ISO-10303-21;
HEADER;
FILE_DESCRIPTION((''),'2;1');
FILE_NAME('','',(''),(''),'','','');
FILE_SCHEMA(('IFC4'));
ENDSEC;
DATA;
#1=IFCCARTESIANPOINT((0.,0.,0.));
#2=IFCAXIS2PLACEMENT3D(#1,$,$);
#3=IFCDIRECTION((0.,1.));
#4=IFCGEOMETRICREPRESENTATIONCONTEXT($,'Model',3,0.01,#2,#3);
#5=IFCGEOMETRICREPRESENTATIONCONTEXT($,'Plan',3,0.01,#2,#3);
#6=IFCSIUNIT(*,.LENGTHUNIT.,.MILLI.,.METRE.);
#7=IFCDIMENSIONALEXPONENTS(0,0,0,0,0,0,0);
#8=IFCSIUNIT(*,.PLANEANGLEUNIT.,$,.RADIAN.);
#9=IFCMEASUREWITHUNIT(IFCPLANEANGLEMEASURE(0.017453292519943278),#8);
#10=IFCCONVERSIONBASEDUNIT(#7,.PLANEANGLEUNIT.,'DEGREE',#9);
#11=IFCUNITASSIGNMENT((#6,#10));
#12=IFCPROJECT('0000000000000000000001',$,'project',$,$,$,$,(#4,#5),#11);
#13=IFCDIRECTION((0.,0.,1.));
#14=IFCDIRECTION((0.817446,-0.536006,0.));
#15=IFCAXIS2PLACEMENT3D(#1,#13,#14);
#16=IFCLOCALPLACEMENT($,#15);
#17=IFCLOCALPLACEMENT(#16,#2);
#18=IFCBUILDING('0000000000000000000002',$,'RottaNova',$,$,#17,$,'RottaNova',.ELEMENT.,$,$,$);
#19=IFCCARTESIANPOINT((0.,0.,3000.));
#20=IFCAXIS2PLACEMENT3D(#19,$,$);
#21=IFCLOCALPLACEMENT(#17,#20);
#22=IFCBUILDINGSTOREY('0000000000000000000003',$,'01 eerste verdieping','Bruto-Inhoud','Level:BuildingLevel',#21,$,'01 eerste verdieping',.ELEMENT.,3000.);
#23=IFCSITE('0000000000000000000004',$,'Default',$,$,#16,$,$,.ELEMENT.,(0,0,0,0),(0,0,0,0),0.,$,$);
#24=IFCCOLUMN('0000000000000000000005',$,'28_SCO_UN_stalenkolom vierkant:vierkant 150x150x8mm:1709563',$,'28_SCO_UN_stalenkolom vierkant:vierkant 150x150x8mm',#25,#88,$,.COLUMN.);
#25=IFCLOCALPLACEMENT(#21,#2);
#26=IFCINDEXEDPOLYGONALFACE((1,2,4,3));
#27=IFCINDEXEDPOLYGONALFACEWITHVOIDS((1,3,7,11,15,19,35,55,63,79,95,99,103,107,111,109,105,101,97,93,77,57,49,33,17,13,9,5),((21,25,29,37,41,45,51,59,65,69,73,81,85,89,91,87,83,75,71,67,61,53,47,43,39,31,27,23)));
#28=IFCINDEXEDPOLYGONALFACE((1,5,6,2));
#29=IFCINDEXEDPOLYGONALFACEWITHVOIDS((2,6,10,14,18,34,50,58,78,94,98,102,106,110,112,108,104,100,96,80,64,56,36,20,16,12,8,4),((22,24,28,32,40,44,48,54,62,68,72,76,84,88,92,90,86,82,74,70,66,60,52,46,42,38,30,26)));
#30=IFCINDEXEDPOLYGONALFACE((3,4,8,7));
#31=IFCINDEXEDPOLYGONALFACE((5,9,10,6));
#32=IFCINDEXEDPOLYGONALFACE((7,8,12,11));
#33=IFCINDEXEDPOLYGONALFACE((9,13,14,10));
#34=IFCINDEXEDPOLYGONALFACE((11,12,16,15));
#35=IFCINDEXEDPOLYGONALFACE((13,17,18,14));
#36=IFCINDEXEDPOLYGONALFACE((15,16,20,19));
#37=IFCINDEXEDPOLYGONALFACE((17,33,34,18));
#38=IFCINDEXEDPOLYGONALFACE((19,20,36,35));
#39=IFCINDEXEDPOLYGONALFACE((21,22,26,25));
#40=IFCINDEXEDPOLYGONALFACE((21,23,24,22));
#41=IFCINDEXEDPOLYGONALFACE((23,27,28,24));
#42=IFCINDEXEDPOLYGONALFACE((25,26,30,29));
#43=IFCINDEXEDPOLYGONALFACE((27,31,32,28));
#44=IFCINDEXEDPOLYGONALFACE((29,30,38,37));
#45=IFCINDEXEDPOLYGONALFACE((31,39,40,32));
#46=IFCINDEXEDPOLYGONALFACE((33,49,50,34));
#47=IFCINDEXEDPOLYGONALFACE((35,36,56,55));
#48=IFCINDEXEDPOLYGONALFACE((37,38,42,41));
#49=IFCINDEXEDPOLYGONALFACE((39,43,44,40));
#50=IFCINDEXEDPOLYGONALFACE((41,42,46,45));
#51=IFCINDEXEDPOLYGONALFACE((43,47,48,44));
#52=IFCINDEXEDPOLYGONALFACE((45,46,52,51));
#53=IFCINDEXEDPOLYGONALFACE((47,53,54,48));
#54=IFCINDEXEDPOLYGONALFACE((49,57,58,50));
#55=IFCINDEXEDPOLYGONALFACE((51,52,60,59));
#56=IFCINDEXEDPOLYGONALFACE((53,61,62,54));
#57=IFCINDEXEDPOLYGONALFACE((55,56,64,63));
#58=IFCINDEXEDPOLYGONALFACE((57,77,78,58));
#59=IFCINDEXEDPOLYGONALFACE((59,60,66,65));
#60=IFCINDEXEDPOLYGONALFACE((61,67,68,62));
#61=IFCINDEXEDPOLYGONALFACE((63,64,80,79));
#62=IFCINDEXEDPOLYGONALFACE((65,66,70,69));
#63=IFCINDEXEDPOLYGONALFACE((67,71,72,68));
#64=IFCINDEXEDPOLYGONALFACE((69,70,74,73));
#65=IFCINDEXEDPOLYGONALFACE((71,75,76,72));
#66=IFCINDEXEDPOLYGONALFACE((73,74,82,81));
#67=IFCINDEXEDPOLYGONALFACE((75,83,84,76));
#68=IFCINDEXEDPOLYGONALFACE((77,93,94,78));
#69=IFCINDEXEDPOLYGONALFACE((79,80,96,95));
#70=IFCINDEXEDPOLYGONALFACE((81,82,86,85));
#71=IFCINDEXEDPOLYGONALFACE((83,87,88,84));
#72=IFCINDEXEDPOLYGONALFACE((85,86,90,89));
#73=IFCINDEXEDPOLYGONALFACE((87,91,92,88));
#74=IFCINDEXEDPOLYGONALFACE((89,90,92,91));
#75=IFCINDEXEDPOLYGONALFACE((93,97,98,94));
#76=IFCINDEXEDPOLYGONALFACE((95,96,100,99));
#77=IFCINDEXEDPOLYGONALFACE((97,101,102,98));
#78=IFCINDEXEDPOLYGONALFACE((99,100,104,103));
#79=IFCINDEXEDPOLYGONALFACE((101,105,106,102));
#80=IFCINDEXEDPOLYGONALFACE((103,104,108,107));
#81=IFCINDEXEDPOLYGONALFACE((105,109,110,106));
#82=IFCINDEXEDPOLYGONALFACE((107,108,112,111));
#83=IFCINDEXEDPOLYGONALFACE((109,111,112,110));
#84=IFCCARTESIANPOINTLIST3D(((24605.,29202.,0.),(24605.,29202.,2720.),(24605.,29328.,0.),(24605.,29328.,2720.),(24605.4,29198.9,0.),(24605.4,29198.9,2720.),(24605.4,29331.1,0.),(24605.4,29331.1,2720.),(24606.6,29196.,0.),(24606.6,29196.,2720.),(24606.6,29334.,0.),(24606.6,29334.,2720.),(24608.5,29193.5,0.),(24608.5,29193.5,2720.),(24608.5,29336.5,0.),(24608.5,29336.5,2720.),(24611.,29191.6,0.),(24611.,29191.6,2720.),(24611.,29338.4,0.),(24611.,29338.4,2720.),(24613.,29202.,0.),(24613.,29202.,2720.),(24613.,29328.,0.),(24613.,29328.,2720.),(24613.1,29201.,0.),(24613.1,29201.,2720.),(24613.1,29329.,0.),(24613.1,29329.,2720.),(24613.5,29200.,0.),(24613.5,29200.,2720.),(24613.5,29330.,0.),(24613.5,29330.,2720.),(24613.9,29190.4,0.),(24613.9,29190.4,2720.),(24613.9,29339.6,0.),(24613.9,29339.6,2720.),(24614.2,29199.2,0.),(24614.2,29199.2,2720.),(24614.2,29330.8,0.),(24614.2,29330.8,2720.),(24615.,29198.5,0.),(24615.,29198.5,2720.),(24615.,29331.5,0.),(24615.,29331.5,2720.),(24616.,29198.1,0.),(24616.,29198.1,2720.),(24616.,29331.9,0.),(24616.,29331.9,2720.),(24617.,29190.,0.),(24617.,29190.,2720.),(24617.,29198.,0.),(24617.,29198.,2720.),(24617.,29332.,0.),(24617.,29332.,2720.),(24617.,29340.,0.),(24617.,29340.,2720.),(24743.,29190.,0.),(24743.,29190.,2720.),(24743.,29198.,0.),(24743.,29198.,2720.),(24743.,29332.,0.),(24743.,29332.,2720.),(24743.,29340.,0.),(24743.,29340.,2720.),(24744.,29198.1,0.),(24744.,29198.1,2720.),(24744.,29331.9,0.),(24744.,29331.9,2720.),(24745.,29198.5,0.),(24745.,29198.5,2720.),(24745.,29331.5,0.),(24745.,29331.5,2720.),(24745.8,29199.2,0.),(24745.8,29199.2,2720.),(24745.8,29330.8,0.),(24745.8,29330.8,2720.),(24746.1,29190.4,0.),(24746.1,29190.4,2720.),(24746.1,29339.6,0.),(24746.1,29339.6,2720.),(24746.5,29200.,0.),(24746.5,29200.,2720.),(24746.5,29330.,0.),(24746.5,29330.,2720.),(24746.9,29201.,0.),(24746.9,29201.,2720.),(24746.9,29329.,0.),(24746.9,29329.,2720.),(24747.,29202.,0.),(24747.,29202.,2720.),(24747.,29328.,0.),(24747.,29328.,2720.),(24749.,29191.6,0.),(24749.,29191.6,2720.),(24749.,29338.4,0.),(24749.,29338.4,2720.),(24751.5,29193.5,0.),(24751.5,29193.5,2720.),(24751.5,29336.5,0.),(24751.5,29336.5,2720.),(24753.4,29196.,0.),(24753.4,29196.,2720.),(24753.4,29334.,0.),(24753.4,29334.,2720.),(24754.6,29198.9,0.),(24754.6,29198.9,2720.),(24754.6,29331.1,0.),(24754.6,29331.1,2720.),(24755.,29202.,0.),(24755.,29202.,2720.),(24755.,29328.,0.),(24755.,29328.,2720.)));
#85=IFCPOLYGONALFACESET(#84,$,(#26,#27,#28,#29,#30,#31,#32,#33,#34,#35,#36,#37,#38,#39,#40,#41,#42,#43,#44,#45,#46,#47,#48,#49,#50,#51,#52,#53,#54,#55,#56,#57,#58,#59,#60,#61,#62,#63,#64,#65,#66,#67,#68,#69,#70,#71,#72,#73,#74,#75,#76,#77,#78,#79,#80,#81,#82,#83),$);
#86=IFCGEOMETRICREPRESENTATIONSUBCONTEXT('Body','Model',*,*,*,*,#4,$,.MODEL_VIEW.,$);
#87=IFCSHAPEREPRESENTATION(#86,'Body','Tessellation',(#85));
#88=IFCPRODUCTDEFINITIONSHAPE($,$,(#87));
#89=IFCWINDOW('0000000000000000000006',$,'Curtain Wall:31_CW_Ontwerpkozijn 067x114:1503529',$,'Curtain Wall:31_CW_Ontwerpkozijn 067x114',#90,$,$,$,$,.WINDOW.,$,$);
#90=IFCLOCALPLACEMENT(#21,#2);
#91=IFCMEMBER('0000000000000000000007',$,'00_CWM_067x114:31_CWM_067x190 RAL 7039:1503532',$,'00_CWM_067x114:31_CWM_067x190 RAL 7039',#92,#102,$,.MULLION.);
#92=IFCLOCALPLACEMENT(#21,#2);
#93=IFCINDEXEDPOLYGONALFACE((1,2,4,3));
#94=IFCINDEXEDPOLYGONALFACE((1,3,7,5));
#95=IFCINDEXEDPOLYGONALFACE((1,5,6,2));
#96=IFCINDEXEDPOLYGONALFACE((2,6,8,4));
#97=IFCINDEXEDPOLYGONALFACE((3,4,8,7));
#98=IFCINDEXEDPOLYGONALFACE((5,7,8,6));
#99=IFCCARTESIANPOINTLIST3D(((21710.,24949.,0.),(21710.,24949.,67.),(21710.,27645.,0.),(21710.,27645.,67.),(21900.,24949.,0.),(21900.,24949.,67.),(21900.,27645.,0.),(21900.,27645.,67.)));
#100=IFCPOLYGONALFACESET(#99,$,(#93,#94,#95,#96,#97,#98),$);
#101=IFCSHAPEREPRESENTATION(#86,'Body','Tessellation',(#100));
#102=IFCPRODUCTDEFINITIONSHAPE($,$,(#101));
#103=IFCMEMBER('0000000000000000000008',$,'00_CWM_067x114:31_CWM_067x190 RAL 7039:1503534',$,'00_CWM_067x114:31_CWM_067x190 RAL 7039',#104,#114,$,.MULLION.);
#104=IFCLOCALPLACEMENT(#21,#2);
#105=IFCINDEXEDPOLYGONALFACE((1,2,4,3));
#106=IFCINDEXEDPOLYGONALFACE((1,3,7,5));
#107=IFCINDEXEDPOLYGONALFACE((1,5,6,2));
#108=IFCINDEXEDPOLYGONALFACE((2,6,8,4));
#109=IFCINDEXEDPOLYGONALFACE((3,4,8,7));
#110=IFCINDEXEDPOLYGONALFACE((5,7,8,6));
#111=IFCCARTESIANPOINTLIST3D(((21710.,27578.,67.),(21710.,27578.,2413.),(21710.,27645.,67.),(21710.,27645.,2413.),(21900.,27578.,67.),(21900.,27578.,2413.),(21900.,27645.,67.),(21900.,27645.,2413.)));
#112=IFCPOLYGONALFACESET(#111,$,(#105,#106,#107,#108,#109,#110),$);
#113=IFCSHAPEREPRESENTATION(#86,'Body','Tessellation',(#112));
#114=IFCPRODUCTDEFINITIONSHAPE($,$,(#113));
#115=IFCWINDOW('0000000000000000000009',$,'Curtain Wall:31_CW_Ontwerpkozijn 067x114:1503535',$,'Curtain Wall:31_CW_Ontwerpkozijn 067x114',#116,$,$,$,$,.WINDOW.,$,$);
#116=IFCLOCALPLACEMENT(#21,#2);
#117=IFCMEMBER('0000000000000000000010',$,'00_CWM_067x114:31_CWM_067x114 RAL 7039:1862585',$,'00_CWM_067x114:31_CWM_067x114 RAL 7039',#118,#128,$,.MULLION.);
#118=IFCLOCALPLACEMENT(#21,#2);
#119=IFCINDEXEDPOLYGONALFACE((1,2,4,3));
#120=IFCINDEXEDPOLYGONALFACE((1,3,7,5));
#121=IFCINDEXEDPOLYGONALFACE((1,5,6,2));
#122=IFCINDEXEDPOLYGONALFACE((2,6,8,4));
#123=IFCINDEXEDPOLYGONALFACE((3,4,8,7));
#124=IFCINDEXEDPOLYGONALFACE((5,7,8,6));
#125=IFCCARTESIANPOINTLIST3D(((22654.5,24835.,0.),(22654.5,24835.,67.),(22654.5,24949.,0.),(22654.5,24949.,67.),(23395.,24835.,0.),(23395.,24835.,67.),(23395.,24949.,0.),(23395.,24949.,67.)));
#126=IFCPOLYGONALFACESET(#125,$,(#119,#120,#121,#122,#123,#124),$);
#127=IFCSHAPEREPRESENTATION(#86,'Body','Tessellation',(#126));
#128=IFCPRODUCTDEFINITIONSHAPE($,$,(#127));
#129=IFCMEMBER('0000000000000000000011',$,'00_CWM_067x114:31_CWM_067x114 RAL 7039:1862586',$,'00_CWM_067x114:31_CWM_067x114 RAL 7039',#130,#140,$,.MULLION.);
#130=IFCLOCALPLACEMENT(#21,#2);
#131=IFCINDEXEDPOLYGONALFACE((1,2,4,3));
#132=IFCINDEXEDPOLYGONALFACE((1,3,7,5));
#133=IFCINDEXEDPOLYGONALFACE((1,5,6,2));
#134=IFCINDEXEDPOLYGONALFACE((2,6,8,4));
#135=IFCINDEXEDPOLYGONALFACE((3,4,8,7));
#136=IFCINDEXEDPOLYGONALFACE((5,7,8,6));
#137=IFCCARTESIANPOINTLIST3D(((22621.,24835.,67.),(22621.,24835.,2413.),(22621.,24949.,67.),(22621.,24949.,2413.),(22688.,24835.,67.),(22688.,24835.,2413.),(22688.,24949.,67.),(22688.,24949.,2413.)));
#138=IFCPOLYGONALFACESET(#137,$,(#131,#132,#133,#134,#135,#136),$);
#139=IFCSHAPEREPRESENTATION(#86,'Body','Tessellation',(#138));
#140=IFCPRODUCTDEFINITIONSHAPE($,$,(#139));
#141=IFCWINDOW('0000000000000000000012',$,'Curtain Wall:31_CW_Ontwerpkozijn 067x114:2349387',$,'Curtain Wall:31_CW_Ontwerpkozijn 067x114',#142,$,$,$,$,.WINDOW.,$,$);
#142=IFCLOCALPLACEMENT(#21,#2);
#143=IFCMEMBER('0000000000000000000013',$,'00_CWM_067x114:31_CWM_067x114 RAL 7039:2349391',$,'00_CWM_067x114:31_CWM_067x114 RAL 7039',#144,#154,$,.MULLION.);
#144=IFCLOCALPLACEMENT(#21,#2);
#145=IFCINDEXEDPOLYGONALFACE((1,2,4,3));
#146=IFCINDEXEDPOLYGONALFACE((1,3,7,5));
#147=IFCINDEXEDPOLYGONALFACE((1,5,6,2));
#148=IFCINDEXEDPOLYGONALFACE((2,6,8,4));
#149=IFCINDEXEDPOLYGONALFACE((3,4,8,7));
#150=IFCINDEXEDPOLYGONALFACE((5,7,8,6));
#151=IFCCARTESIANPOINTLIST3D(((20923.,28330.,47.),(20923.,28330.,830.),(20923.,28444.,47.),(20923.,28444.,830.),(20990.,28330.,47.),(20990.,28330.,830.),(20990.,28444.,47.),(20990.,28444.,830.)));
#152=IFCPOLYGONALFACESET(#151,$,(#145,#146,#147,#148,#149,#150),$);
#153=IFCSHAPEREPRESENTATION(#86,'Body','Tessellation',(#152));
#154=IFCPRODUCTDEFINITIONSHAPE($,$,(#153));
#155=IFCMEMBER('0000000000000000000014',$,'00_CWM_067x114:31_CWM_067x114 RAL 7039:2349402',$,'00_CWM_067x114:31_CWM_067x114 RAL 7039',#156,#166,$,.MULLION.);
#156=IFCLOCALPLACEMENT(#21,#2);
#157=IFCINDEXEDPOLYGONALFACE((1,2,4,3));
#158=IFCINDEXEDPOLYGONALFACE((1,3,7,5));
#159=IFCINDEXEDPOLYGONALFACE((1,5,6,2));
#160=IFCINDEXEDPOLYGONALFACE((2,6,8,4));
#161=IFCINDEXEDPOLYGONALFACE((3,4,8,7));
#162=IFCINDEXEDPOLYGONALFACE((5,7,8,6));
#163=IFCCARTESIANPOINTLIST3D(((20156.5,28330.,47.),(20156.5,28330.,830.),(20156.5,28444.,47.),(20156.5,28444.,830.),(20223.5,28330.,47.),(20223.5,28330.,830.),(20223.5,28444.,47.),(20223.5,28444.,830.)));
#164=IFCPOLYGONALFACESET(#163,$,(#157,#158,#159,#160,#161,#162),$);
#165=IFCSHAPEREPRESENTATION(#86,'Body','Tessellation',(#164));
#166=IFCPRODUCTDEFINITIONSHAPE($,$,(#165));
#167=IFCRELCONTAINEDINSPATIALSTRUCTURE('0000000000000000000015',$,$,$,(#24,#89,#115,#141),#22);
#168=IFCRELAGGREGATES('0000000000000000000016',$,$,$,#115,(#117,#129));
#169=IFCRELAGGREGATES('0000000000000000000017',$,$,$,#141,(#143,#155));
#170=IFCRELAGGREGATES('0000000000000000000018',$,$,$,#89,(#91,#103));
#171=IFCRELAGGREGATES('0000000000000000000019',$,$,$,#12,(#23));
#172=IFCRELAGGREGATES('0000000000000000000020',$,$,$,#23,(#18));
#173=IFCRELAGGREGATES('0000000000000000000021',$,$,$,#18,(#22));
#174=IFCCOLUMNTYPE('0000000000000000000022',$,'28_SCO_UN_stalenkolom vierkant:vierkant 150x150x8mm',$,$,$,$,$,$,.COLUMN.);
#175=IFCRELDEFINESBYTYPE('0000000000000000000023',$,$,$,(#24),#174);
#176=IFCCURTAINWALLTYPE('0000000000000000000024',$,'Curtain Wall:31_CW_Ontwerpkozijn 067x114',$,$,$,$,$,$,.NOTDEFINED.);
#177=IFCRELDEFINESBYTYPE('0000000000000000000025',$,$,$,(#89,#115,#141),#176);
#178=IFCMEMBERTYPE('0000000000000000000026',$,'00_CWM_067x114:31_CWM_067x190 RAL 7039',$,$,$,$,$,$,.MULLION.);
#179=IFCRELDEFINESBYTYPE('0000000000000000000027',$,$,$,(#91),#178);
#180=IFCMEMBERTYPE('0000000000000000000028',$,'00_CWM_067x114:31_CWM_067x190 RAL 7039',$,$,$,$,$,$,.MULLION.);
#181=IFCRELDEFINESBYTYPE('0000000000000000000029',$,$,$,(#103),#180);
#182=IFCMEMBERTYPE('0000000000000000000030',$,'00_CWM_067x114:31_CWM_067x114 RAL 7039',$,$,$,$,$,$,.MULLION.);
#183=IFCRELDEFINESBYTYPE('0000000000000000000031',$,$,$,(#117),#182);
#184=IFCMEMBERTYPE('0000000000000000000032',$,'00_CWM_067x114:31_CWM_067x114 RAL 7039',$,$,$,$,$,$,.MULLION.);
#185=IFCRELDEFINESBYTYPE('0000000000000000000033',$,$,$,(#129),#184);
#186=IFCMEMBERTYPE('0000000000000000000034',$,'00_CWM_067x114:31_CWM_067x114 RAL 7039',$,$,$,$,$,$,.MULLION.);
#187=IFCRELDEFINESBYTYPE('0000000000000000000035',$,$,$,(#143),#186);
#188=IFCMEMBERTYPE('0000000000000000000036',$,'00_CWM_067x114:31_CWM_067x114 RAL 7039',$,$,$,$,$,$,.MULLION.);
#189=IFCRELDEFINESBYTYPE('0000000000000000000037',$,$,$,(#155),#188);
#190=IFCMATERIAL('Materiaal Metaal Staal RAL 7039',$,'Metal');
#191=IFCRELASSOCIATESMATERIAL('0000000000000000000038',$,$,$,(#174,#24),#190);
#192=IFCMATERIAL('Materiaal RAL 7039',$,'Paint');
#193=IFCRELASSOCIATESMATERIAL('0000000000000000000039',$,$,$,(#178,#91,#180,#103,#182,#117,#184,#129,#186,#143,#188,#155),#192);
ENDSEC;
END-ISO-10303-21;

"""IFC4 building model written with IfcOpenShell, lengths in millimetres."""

from ifc_helpers import new_model, entity, si_unit, converted_unit, direction, frame, origin, place, context, subcontext, project, spatial, line, arc, indexed_curve, outline, extrude, source, transform, mapped, material, type_object, type_shapes, element, aggregate, save


model = new_model("IFC4")

# Units and contexts
model_context = context("Model", 3, precision=0.01, world=origin(), true_north=direction((0.0, 1.0)))
plan_context = context("Plan", 3, precision=0.01, world=origin(), true_north=direction((0.0, 1.0)))
body_context = subcontext(model_context, "Body", "Model", "MODEL_VIEW")
ifc_project = project(units=[si_unit("LENGTHUNIT", "METRE", prefix="MILLI"), converted_unit("PLANEANGLEUNIT", "DEGREE", entity("IfcPlaneAngleMeasure", 0.017453292519943278), si_unit("PLANEANGLEUNIT", "RADIAN"), dimensions=[0, 0, 0, 0, 0, 0, 0])], contexts=[model_context, plan_context])

# Site, building, storey
site_placement = place(None, frame((0.0, 0.0, 0.0), z_axis=(0.0, 0.0, 1.0), x_axis=(0.817446, -0.536006, 0.0)))
site = spatial("IfcSite", under=ifc_project, at=site_placement, Name="Default", CompositionType="ELEMENT", RefLatitude=(0, 0, 0, 0), RefLongitude=(0, 0, 0, 0), RefElevation=0.0)
building_placement = place(site_placement, origin())
building = spatial("IfcBuilding", under=site, at=building_placement, Name="RottaNova", LongName="RottaNova", CompositionType="ELEMENT")
storey_placement = place(building_placement, frame((0.0, 0.0, 3000.0)))
storey = spatial("IfcBuildingStorey", under=building, at=storey_placement, Name="01 eerste verdieping", Description="Bruto-Inhoud", ObjectType="Level:BuildingLevel", LongName="01 eerste verdieping", CompositionType="ELEMENT", Elevation=3000.0)

# Column
ifc_material_1 = material(Name="Materiaal Metaal Staal RAL 7039", Category="Metal")
column_type = type_object("IfcColumnType", Name="28_SCO_UN_stalenkolom vierkant:vierkant 150x150x8mm", PredefinedType="COLUMN", material=ifc_material_1)
shared_shape_1 = source(origin(), body_context, "Body", "SweptSolid", [
    extrude(outline(indexed_curve([(-63.0, -75.0), (63.0, -75.0), (71.5, -71.5), (75.0, -63.0), (75.0, 63.0), (71.5, 71.5), (63.0, 75.0), (-63.0, 75.0), (-71.5, 71.5), (-75.0, 63.0), (-75.0, -63.0), (-71.5, -71.5)], segments=[line(1, 2), arc(2, 3, 4), line(4, 5), arc(5, 6, 7), line(7, 8), arc(8, 9, 10), line(10, 11), arc(11, 12, 1)], self_intersect=False), holes=[indexed_curve([(67.0, -63.0), (65.8, -65.8), (63.0, -67.0), (-63.0, -67.0), (-65.8, -65.8), (-67.0, -63.0), (-67.0, 63.0), (-65.8, 65.8), (-63.0, 67.0), (63.0, 67.0), (65.8, 65.8), (67.0, 63.0)], segments=[arc(1, 2, 3), line(3, 4), arc(4, 5, 6), line(6, 7), arc(7, 8, 9), line(9, 10), arc(10, 11, 12), line(12, 1)], self_intersect=False)]), frame((0.0, 0.0, 3000.0), z_axis=(0.0, 0.0, 1.0), x_axis=(-1.0, 0.0, 0.0)), (0.0, 0.0, 1.0), 2720.0),
])
type_shapes(column_type, [shared_shape_1])
column_placement = place(storey_placement, frame((24680.0, 29265.0, -3000.0)))
element("IfcColumn", 1, at=column_placement, inside=storey, type_object=column_type, material=ifc_material_1, Name="28_SCO_UN_stalenkolom vierkant:vierkant 150x150x8mm:1709563", ObjectType="28_SCO_UN_stalenkolom vierkant:vierkant 150x150x8mm", PredefinedType="COLUMN", context=body_context, shape_type="MappedRepresentation", body=[
    mapped(shared_shape_1, transform((0.0, 0.0, 0.0), scale=1.0)),
])

# Windows, members
curtain_wall_type = type_object("IfcCurtainWallType", Name="Curtain Wall:31_CW_Ontwerpkozijn 067x114", PredefinedType="NOTDEFINED")
window_1_placement = place(storey_placement, frame((0.0, 0.0, -3000.0)))
window_1 = element("IfcWindow", 2, at=window_1_placement, inside=storey, type_object=curtain_wall_type, Name="Curtain Wall:31_CW_Ontwerpkozijn 067x114:1503529", ObjectType="Curtain Wall:31_CW_Ontwerpkozijn 067x114", PredefinedType="WINDOW")
ifc_material_2 = material(Name="Materiaal RAL 7039", Category="Paint")
member_type_1 = type_object("IfcMemberType", Name="00_CWM_067x114:31_CWM_067x190 RAL 7039", PredefinedType="MULLION", material=ifc_material_2)
shared_shape_2 = source(origin(), body_context, "Body", "SweptSolid", [
    extrude(outline(indexed_curve([(-33.5, -95.0), (33.5, -95.0), (33.5, 95.0), (-33.5, 95.0), (-33.5, -95.0)], self_intersect=False)), frame((-33.5, -95.0, -2696.0), z_axis=(0.0, 0.0, 1.0), x_axis=(-1.0, 0.0, 0.0)), (0.0, 0.0, 1.0), 2696.0),
])
type_shapes(member_type_1, [shared_shape_2])
member_1_placement = place(window_1_placement, frame((21710.0, 27645.0, 3000.0), z_axis=(0.0, 1.0, 0.0), x_axis=(0.0, 0.0, -1.0)))
member_1 = element("IfcMember", 3, at=member_1_placement, type_object=member_type_1, material=ifc_material_2, Name="00_CWM_067x114:31_CWM_067x190 RAL 7039:1503532", ObjectType="00_CWM_067x114:31_CWM_067x190 RAL 7039", PredefinedType="MULLION", context=body_context, shape_type="MappedRepresentation", body=[
    mapped(shared_shape_2, transform((0.0, 0.0, 0.0), scale=1.0)),
])
member_type_2 = type_object("IfcMemberType", Name="00_CWM_067x114:31_CWM_067x190 RAL 7039", PredefinedType="MULLION", material=ifc_material_2)
shared_shape_3 = source(origin(), body_context, "Body", "SweptSolid", [
    extrude(outline(indexed_curve([(-33.5, -95.0), (33.5, -95.0), (33.5, 95.0), (-33.5, 95.0), (-33.5, -95.0)], self_intersect=False)), frame((-33.5, -95.0, -2346.0), z_axis=(0.0, 0.0, 1.0), x_axis=(-1.0, 0.0, 0.0)), (0.0, 0.0, 1.0), 2346.0),
])
type_shapes(member_type_2, [shared_shape_3])
member_2_placement = place(window_1_placement, frame((21710.0, 27645.0, 5413.0), z_axis=(0.0, 0.0, 1.0), x_axis=(0.0, 1.0, 0.0)))
member_2 = element("IfcMember", 4, at=member_2_placement, type_object=member_type_2, material=ifc_material_2, Name="00_CWM_067x114:31_CWM_067x190 RAL 7039:1503534", ObjectType="00_CWM_067x114:31_CWM_067x190 RAL 7039", PredefinedType="MULLION", context=body_context, shape_type="MappedRepresentation", body=[
    mapped(shared_shape_3, transform((0.0, 0.0, 0.0), scale=1.0)),
])
window_2_placement = place(storey_placement, frame((0.0, 0.0, -3000.0)))
window_2 = element("IfcWindow", 5, at=window_2_placement, inside=storey, type_object=curtain_wall_type, Name="Curtain Wall:31_CW_Ontwerpkozijn 067x114:1503535", ObjectType="Curtain Wall:31_CW_Ontwerpkozijn 067x114", PredefinedType="WINDOW")
member_type_3 = type_object("IfcMemberType", Name="00_CWM_067x114:31_CWM_067x114 RAL 7039", PredefinedType="MULLION", material=ifc_material_2)
shared_shape_4 = source(origin(), body_context, "Body", "SweptSolid", [
    extrude(outline(indexed_curve([(-33.5, -57.0), (33.5, -57.0), (33.5, 57.0), (-33.5, 57.0), (-33.5, -57.0)], self_intersect=False)), frame((-33.5, -57.0, -740.5), z_axis=(0.0, 0.0, 1.0), x_axis=(-1.0, 0.0, 0.0)), (0.0, 0.0, 1.0), 740.5),
])
type_shapes(member_type_3, [shared_shape_4])
member_3_placement = place(window_2_placement, frame((22654.5, 24835.0, 3000.0), z_axis=(-1.0, 0.0, 0.0), x_axis=(0.0, 0.0, -1.0)))
member_3 = element("IfcMember", 6, at=member_3_placement, type_object=member_type_3, material=ifc_material_2, Name="00_CWM_067x114:31_CWM_067x114 RAL 7039:1862585", ObjectType="00_CWM_067x114:31_CWM_067x114 RAL 7039", PredefinedType="MULLION", context=body_context, shape_type="MappedRepresentation", body=[
    mapped(shared_shape_4, transform((0.0, 0.0, 0.0), scale=1.0)),
])
member_type_4 = type_object("IfcMemberType", Name="00_CWM_067x114:31_CWM_067x114 RAL 7039", PredefinedType="MULLION", material=ifc_material_2)
shared_shape_5 = source(origin(), body_context, "Body", "SweptSolid", [
    extrude(outline(indexed_curve([(-33.5, -57.0), (33.5, -57.0), (33.5, 57.0), (-33.5, 57.0), (-33.5, -57.0)], self_intersect=False)), frame((0.0, -57.0, -2346.0), z_axis=(0.0, 0.0, 1.0), x_axis=(-1.0, 0.0, 0.0)), (0.0, 0.0, 1.0), 2346.0),
])
type_shapes(member_type_4, [shared_shape_5])
member_4_placement = place(window_2_placement, frame((22654.5, 24835.0, 3067.0), z_axis=(0.0, 0.0, -1.0), x_axis=(1.0, 0.0, 0.0)))
member_4 = element("IfcMember", 7, at=member_4_placement, type_object=member_type_4, material=ifc_material_2, Name="00_CWM_067x114:31_CWM_067x114 RAL 7039:1862586", ObjectType="00_CWM_067x114:31_CWM_067x114 RAL 7039", PredefinedType="MULLION", context=body_context, shape_type="MappedRepresentation", body=[
    mapped(shared_shape_5, transform((0.0, 0.0, 0.0), scale=1.0)),
])
aggregate(window_2, [member_3, member_4])

# Window, members
window_3_placement = place(storey_placement, frame((0.0, 0.0, -3000.0)))
window_3 = element("IfcWindow", 8, at=window_3_placement, inside=storey, type_object=curtain_wall_type, Name="Curtain Wall:31_CW_Ontwerpkozijn 067x114:2349387", ObjectType="Curtain Wall:31_CW_Ontwerpkozijn 067x114", PredefinedType="WINDOW")
member_type_5 = type_object("IfcMemberType", Name="00_CWM_067x114:31_CWM_067x114 RAL 7039", PredefinedType="MULLION", material=ifc_material_2)
shared_shape_6 = source(origin(), body_context, "Body", "SweptSolid", [
    extrude(outline(indexed_curve([(-33.5, -57.0), (33.5, -57.0), (33.5, 57.0), (-33.5, 57.0), (-33.5, -57.0)], self_intersect=False)), frame((-33.5, -57.0, -783.0), z_axis=(0.0, 0.0, 1.0), x_axis=(-1.0, 0.0, 0.0)), (0.0, 0.0, 1.0), 783.0),
])
type_shapes(member_type_5, [shared_shape_6])
member_5_placement = place(window_3_placement, frame((20990.0, 28330.0, 3047.0), z_axis=(0.0, 0.0, -1.0), x_axis=(1.0, 0.0, 0.0)))
member_5 = element("IfcMember", 9, at=member_5_placement, type_object=member_type_5, material=ifc_material_2, Name="00_CWM_067x114:31_CWM_067x114 RAL 7039:2349391", ObjectType="00_CWM_067x114:31_CWM_067x114 RAL 7039", PredefinedType="MULLION", context=body_context, shape_type="MappedRepresentation", body=[
    mapped(shared_shape_6, transform((0.0, 0.0, 0.0), scale=1.0)),
])
member_type_6 = type_object("IfcMemberType", Name="00_CWM_067x114:31_CWM_067x114 RAL 7039", PredefinedType="MULLION", material=ifc_material_2)
shared_shape_7 = source(origin(), body_context, "Body", "SweptSolid", [
    extrude(outline(indexed_curve([(-33.5, -57.0), (33.5, -57.0), (33.5, 57.0), (-33.5, 57.0), (-33.5, -57.0)], self_intersect=False)), frame((0.0, -57.0, -783.0), z_axis=(0.0, 0.0, 1.0), x_axis=(-1.0, 0.0, 0.0)), (0.0, 0.0, 1.0), 783.0),
])
type_shapes(member_type_6, [shared_shape_7])
member_6_placement = place(window_3_placement, frame((20190.0, 28330.0, 3047.0), z_axis=(0.0, 0.0, -1.0), x_axis=(1.0, 0.0, 0.0)))
member_6 = element("IfcMember", 10, at=member_6_placement, type_object=member_type_6, material=ifc_material_2, Name="00_CWM_067x114:31_CWM_067x114 RAL 7039:2349402", ObjectType="00_CWM_067x114:31_CWM_067x114 RAL 7039", PredefinedType="MULLION", context=body_context, shape_type="MappedRepresentation", body=[
    mapped(shared_shape_7, transform((0.0, 0.0, 0.0), scale=1.0)),
])
aggregate(window_3, [member_5, member_6])

aggregate(window_1, [member_1, member_2])

save(model, "model.ifc")
